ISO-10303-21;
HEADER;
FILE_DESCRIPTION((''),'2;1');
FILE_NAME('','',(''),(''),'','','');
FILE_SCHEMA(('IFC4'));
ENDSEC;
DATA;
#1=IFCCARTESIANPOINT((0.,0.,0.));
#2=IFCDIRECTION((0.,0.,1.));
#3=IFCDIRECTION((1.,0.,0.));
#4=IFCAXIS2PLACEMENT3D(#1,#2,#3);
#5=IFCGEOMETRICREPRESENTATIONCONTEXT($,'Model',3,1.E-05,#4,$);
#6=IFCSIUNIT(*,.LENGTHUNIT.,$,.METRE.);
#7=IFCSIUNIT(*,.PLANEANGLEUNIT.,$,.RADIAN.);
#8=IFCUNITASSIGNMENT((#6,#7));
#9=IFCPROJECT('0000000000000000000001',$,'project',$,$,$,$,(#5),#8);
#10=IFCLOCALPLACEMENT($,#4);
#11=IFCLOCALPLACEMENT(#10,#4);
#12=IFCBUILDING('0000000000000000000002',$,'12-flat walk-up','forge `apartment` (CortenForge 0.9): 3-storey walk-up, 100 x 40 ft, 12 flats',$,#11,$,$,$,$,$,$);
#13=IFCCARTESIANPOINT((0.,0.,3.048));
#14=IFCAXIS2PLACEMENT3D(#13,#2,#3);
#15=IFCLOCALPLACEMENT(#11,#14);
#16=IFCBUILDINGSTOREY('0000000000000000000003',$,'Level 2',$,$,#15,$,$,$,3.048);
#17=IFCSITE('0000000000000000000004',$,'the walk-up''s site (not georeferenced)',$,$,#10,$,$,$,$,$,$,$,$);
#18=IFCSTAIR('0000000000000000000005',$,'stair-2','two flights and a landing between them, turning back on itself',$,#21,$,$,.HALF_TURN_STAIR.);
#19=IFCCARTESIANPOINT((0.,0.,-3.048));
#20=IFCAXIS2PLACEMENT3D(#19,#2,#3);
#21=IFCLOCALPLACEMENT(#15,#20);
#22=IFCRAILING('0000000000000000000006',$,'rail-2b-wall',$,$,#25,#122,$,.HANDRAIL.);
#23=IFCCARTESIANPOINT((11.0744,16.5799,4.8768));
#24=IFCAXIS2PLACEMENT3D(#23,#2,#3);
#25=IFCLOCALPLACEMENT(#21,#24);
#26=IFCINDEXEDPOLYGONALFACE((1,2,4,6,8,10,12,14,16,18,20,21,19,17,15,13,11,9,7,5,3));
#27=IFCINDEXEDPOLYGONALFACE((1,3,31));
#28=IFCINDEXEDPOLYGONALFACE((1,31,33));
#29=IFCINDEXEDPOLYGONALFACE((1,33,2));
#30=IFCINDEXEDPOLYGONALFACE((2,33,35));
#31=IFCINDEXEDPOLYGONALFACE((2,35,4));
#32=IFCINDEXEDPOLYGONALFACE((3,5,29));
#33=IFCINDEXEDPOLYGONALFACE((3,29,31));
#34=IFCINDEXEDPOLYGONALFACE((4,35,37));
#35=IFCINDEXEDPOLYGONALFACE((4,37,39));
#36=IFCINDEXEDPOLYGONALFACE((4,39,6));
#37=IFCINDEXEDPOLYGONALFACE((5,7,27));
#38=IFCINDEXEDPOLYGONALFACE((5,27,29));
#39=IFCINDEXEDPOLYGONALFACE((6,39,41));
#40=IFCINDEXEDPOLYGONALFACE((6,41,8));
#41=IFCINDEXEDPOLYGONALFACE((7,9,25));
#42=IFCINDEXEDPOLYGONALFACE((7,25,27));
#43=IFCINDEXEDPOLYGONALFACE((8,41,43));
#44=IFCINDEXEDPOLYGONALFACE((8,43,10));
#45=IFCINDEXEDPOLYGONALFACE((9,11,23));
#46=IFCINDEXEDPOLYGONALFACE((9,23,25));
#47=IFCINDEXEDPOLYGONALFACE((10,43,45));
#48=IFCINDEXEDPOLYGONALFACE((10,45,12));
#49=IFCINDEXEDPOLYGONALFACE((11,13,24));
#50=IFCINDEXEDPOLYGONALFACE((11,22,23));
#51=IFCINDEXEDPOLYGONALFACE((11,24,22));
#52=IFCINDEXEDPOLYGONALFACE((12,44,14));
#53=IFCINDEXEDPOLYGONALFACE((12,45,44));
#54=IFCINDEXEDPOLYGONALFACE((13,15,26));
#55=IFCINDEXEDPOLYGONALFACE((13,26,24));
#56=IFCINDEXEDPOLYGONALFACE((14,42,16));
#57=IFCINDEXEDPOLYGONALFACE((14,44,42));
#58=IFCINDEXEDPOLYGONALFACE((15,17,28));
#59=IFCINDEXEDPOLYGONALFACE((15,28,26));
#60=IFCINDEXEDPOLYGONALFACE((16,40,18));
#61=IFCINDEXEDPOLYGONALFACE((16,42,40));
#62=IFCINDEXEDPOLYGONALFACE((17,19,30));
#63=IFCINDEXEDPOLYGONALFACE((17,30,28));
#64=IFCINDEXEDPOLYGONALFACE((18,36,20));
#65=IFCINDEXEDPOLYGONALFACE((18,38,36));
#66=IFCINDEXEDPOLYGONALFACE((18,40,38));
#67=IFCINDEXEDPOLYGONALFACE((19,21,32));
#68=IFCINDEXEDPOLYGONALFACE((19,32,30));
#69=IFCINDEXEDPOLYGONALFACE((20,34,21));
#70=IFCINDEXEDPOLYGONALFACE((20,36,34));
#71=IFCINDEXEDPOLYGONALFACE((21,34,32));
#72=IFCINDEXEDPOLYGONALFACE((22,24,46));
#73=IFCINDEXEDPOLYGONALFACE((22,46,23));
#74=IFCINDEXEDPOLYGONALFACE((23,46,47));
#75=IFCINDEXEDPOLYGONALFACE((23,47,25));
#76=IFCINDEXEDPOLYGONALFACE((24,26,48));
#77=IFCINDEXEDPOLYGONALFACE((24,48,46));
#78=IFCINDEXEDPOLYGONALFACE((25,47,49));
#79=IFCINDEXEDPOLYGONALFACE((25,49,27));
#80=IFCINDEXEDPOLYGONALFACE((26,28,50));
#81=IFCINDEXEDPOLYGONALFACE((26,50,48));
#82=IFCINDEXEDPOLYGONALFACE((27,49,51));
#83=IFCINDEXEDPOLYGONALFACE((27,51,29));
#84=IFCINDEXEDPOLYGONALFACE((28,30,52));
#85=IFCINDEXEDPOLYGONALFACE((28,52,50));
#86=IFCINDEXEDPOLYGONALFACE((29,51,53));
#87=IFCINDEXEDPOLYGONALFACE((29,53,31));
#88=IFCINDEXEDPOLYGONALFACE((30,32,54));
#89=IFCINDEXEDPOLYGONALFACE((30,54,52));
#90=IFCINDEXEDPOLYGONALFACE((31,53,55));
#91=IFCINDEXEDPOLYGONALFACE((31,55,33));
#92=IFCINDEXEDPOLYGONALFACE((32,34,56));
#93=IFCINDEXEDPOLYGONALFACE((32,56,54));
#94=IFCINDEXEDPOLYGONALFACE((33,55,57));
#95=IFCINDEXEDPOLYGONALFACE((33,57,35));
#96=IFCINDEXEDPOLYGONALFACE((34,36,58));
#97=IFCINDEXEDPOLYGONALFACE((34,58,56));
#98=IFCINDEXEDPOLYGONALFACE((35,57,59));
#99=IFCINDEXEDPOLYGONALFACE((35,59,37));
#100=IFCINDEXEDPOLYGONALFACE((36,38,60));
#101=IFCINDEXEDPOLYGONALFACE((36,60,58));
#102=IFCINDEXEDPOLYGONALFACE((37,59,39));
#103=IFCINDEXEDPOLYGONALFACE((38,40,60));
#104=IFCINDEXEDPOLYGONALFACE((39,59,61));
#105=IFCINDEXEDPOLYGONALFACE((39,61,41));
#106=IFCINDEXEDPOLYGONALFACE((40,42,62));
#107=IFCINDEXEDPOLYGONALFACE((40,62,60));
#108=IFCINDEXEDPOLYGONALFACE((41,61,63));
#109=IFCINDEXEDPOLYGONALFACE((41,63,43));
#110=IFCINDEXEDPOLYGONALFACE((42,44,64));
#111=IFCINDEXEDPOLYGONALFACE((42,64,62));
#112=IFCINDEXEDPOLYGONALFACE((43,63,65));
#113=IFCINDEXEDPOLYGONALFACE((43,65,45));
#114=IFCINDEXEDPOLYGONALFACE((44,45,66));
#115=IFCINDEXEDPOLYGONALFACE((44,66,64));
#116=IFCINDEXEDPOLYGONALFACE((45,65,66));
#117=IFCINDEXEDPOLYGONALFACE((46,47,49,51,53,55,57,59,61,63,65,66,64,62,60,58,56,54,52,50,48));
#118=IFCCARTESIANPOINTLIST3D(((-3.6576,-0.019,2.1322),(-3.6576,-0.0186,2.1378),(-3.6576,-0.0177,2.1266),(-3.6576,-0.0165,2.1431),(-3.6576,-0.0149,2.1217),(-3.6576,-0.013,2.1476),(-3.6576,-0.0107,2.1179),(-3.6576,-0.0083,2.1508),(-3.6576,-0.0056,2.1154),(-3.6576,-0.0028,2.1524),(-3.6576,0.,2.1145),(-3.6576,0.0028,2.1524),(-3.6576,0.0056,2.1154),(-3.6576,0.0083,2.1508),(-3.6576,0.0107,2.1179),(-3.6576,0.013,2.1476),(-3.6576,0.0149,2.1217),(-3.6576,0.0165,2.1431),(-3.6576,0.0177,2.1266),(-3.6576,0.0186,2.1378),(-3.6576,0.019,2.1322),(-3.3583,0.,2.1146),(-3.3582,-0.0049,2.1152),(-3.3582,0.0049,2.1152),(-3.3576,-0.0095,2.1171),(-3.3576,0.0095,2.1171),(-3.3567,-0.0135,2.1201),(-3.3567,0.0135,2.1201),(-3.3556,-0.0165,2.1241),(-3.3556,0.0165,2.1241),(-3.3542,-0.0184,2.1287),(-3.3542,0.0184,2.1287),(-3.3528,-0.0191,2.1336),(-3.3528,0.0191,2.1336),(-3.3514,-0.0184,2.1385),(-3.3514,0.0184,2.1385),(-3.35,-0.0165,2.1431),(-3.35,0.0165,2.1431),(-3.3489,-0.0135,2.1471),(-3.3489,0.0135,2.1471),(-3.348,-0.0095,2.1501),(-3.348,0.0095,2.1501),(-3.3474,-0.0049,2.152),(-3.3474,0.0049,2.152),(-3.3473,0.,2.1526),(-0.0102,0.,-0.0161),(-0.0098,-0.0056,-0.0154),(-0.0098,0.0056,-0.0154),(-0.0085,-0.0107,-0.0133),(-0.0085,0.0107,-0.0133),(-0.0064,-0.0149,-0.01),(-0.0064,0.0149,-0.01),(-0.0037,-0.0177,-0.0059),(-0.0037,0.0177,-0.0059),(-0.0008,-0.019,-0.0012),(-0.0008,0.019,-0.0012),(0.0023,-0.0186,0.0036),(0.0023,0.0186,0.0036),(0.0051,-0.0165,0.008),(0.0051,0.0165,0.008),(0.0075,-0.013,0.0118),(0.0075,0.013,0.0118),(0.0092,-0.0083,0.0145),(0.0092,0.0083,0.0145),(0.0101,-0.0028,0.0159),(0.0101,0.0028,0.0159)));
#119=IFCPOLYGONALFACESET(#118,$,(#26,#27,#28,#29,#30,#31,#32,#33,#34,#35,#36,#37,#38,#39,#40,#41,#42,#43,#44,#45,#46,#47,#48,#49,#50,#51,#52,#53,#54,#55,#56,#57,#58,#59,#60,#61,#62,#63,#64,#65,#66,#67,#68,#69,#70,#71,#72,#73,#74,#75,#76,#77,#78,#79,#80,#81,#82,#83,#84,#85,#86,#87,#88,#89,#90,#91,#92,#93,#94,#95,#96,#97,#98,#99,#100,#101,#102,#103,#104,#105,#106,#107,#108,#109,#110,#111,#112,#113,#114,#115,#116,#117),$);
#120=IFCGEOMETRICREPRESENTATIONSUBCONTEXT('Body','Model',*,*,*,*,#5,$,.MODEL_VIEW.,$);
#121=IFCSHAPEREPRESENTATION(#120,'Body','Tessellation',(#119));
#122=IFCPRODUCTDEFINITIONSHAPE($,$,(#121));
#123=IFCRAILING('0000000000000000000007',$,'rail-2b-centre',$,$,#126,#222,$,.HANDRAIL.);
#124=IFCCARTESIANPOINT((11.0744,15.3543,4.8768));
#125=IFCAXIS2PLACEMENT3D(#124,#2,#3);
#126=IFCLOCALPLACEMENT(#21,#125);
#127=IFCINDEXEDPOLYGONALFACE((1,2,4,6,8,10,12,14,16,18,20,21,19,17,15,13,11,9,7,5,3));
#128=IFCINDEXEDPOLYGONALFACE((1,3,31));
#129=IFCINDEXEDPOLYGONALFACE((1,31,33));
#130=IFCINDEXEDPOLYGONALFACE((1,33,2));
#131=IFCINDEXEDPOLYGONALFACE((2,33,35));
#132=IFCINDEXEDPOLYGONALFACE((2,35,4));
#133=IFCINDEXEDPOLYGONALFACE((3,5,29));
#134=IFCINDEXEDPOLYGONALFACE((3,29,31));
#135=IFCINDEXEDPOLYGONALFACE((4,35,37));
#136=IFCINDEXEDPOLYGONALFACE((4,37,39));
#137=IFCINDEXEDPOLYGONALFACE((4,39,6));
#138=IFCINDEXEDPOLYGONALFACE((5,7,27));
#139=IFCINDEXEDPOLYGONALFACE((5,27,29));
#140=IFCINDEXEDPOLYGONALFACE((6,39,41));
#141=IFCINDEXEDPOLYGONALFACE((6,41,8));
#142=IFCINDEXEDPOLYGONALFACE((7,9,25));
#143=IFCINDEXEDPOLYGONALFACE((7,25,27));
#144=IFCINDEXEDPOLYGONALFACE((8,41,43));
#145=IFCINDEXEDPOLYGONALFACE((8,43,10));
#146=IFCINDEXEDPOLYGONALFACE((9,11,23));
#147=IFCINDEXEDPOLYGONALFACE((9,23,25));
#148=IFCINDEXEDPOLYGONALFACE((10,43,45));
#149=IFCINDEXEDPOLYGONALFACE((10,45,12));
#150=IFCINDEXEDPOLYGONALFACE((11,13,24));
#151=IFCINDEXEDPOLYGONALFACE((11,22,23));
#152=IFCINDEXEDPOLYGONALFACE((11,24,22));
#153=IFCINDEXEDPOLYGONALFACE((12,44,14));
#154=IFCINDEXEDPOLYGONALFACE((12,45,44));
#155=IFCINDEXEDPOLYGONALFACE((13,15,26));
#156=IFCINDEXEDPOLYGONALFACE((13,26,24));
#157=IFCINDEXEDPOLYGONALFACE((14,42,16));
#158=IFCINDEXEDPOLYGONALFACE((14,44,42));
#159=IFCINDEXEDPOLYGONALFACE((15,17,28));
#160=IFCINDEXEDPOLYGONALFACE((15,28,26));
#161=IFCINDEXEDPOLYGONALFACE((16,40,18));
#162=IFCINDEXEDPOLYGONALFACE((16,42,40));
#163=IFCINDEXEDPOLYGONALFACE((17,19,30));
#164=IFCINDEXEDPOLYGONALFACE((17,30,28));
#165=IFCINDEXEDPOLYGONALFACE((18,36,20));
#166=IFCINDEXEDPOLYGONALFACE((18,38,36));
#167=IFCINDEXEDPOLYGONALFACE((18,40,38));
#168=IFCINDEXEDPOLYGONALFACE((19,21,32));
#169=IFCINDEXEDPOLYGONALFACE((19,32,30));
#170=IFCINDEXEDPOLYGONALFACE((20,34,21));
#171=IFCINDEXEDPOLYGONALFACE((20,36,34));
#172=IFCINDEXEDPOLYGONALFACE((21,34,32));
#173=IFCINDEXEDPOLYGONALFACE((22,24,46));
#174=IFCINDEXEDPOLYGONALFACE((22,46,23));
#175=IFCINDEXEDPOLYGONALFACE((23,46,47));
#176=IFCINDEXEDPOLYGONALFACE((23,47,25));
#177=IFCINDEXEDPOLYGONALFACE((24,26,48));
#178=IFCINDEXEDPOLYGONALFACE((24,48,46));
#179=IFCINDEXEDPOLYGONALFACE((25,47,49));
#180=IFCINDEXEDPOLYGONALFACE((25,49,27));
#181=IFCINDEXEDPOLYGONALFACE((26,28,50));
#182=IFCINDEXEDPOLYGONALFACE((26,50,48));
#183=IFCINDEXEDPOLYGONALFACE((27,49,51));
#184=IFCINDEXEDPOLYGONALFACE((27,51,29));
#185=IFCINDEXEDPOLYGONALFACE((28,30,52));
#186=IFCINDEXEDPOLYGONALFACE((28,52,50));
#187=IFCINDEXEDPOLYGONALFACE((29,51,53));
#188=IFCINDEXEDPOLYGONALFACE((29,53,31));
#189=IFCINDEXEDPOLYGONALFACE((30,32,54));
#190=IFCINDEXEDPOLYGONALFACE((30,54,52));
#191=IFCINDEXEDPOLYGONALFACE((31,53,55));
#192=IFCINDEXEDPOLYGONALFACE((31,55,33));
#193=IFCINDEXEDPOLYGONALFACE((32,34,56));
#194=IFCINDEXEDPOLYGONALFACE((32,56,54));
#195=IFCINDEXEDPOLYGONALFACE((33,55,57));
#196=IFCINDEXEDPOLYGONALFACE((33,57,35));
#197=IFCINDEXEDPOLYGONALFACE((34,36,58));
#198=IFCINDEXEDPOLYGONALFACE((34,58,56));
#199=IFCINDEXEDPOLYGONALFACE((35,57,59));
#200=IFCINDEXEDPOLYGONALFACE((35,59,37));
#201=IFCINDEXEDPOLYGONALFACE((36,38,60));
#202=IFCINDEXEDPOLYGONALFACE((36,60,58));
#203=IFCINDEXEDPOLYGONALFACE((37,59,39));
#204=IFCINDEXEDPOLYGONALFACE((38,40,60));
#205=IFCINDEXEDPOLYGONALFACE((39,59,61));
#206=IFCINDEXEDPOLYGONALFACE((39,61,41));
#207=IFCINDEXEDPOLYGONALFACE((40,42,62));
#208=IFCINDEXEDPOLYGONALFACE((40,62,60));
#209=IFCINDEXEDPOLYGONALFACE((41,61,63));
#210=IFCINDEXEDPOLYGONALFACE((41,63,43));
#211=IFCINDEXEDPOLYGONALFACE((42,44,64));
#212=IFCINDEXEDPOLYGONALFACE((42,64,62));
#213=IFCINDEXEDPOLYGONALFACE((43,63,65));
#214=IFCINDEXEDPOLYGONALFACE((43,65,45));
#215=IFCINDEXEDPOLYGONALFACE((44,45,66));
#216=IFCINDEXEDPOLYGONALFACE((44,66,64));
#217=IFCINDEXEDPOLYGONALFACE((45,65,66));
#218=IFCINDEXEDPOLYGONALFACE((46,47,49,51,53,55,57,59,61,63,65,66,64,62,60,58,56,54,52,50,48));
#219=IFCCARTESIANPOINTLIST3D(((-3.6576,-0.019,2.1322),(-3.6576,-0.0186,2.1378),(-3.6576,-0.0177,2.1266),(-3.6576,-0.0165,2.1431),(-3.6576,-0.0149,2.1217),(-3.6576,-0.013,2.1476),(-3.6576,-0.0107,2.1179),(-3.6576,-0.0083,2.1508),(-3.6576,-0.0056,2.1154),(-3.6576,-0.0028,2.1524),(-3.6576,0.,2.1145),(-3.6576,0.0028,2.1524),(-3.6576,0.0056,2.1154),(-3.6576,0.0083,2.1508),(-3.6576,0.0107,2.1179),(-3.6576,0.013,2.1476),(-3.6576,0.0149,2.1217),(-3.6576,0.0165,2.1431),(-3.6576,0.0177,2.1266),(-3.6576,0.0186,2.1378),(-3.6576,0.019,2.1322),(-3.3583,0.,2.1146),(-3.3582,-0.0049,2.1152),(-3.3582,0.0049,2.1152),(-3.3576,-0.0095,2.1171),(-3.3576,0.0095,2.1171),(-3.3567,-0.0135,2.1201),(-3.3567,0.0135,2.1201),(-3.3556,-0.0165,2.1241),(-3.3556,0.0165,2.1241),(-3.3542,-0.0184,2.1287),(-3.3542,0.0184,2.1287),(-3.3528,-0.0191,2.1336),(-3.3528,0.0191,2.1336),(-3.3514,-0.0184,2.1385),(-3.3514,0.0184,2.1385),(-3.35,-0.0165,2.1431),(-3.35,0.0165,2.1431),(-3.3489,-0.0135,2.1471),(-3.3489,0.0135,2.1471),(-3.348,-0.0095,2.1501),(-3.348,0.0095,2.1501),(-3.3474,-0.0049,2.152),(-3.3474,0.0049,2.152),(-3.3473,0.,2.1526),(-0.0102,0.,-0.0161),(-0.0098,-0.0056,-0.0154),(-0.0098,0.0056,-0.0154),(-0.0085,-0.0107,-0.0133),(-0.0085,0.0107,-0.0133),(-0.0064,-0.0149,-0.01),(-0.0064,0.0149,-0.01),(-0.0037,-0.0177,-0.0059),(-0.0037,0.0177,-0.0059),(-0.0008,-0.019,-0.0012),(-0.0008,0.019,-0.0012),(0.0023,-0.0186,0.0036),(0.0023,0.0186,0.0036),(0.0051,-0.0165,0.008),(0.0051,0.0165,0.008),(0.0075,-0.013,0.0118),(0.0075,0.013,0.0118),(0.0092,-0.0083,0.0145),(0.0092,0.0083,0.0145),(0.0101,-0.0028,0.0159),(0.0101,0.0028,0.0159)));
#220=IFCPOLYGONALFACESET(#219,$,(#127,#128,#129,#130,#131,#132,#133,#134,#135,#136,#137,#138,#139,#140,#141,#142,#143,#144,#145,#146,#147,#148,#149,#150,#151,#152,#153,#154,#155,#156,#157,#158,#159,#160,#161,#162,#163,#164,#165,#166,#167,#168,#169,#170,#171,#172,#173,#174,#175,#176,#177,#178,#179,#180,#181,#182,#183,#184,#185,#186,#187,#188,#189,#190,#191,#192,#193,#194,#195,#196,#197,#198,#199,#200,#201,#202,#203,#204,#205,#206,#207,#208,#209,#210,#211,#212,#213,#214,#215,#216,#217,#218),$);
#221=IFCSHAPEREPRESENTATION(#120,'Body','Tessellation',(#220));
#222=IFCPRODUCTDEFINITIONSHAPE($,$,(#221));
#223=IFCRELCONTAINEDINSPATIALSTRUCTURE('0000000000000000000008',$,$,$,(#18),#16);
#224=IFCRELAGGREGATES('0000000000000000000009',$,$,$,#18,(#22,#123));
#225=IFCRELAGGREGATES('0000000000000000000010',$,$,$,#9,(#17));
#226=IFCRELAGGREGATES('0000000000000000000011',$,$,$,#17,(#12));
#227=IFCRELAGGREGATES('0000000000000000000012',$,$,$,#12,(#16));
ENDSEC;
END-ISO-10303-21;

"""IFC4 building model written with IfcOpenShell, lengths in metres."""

from ifc_helpers import new_model, entity, si_unit, frame, origin_with_axes, place, context, subcontext, project, spatial, element, aggregate, save


model = new_model("IFC4")

# Units and contexts
model_context = context("Model", 3, precision=1e-05, world=origin_with_axes())
body_context = subcontext(model_context, "Body", "Model", "MODEL_VIEW")
ifc_project = project(units=[si_unit("LENGTHUNIT", "METRE"), si_unit("PLANEANGLEUNIT", "RADIAN")], contexts=[model_context])

# Site, building, storey
site_placement = place(None, origin_with_axes())
site = spatial("IfcSite", under=ifc_project, at=site_placement, Name="the walk-up's site (not georeferenced)")
building_placement = place(site_placement, origin_with_axes())
building = spatial("IfcBuilding", under=site, at=building_placement, Name="12-flat walk-up", Description="forge `apartment` (CortenForge 0.9): 3-storey walk-up, 100 x 40 ft, 12 flats")
storey_placement = place(building_placement, frame((0.0, 0.0, 3.048), z_axis=(0.0, 0.0, 1.0), x_axis=(1.0, 0.0, 0.0)))
storey = spatial("IfcBuildingStorey", under=building, at=storey_placement, Name="Level 2", Elevation=3.048)

# Stair, railings
stair_placement = place(storey_placement, frame((0.0, 0.0, -3.048), z_axis=(0.0, 0.0, 1.0), x_axis=(1.0, 0.0, 0.0)))
stair = element("IfcStair", 1, at=stair_placement, inside=storey, Name="stair-2", Description="two flights and a landing between them, turning back on itself", PredefinedType="HALF_TURN_STAIR")
railing_1_placement = place(stair_placement, frame((11.0744, 16.5799, 4.8768), z_axis=(0.0, 0.0, 1.0), x_axis=(1.0, 0.0, 0.0)))
railing_1 = element("IfcRailing", 2, at=railing_1_placement, Name="rail-2b-wall", PredefinedType="HANDRAIL", context=body_context, shape_type="AdvancedSweptSolid", body=[
    entity("IfcSweptDiskSolid", entity("IfcPolyline", [entity("IfcCartesianPoint", [0.0, 0.0, 0.0]), entity("IfcCartesianPoint", [-3.3528, 0.0, 2.1336]), entity("IfcCartesianPoint", [-3.6576, 0.0, 2.1336])]), 0.0191),
])
railing_2_placement = place(stair_placement, frame((11.0744, 15.3543, 4.8768), z_axis=(0.0, 0.0, 1.0), x_axis=(1.0, 0.0, 0.0)))
railing_2 = element("IfcRailing", 3, at=railing_2_placement, Name="rail-2b-centre", PredefinedType="HANDRAIL", context=body_context, shape_type="AdvancedSweptSolid", body=[
    entity("IfcSweptDiskSolid", entity("IfcPolyline", [entity("IfcCartesianPoint", [0.0, 0.0, 0.0]), entity("IfcCartesianPoint", [-3.3528, 0.0, 2.1336]), entity("IfcCartesianPoint", [-3.6576, 0.0, 2.1336])]), 0.0191),
])
aggregate(stair, [railing_1, railing_2])

save(model, "model.ifc")
